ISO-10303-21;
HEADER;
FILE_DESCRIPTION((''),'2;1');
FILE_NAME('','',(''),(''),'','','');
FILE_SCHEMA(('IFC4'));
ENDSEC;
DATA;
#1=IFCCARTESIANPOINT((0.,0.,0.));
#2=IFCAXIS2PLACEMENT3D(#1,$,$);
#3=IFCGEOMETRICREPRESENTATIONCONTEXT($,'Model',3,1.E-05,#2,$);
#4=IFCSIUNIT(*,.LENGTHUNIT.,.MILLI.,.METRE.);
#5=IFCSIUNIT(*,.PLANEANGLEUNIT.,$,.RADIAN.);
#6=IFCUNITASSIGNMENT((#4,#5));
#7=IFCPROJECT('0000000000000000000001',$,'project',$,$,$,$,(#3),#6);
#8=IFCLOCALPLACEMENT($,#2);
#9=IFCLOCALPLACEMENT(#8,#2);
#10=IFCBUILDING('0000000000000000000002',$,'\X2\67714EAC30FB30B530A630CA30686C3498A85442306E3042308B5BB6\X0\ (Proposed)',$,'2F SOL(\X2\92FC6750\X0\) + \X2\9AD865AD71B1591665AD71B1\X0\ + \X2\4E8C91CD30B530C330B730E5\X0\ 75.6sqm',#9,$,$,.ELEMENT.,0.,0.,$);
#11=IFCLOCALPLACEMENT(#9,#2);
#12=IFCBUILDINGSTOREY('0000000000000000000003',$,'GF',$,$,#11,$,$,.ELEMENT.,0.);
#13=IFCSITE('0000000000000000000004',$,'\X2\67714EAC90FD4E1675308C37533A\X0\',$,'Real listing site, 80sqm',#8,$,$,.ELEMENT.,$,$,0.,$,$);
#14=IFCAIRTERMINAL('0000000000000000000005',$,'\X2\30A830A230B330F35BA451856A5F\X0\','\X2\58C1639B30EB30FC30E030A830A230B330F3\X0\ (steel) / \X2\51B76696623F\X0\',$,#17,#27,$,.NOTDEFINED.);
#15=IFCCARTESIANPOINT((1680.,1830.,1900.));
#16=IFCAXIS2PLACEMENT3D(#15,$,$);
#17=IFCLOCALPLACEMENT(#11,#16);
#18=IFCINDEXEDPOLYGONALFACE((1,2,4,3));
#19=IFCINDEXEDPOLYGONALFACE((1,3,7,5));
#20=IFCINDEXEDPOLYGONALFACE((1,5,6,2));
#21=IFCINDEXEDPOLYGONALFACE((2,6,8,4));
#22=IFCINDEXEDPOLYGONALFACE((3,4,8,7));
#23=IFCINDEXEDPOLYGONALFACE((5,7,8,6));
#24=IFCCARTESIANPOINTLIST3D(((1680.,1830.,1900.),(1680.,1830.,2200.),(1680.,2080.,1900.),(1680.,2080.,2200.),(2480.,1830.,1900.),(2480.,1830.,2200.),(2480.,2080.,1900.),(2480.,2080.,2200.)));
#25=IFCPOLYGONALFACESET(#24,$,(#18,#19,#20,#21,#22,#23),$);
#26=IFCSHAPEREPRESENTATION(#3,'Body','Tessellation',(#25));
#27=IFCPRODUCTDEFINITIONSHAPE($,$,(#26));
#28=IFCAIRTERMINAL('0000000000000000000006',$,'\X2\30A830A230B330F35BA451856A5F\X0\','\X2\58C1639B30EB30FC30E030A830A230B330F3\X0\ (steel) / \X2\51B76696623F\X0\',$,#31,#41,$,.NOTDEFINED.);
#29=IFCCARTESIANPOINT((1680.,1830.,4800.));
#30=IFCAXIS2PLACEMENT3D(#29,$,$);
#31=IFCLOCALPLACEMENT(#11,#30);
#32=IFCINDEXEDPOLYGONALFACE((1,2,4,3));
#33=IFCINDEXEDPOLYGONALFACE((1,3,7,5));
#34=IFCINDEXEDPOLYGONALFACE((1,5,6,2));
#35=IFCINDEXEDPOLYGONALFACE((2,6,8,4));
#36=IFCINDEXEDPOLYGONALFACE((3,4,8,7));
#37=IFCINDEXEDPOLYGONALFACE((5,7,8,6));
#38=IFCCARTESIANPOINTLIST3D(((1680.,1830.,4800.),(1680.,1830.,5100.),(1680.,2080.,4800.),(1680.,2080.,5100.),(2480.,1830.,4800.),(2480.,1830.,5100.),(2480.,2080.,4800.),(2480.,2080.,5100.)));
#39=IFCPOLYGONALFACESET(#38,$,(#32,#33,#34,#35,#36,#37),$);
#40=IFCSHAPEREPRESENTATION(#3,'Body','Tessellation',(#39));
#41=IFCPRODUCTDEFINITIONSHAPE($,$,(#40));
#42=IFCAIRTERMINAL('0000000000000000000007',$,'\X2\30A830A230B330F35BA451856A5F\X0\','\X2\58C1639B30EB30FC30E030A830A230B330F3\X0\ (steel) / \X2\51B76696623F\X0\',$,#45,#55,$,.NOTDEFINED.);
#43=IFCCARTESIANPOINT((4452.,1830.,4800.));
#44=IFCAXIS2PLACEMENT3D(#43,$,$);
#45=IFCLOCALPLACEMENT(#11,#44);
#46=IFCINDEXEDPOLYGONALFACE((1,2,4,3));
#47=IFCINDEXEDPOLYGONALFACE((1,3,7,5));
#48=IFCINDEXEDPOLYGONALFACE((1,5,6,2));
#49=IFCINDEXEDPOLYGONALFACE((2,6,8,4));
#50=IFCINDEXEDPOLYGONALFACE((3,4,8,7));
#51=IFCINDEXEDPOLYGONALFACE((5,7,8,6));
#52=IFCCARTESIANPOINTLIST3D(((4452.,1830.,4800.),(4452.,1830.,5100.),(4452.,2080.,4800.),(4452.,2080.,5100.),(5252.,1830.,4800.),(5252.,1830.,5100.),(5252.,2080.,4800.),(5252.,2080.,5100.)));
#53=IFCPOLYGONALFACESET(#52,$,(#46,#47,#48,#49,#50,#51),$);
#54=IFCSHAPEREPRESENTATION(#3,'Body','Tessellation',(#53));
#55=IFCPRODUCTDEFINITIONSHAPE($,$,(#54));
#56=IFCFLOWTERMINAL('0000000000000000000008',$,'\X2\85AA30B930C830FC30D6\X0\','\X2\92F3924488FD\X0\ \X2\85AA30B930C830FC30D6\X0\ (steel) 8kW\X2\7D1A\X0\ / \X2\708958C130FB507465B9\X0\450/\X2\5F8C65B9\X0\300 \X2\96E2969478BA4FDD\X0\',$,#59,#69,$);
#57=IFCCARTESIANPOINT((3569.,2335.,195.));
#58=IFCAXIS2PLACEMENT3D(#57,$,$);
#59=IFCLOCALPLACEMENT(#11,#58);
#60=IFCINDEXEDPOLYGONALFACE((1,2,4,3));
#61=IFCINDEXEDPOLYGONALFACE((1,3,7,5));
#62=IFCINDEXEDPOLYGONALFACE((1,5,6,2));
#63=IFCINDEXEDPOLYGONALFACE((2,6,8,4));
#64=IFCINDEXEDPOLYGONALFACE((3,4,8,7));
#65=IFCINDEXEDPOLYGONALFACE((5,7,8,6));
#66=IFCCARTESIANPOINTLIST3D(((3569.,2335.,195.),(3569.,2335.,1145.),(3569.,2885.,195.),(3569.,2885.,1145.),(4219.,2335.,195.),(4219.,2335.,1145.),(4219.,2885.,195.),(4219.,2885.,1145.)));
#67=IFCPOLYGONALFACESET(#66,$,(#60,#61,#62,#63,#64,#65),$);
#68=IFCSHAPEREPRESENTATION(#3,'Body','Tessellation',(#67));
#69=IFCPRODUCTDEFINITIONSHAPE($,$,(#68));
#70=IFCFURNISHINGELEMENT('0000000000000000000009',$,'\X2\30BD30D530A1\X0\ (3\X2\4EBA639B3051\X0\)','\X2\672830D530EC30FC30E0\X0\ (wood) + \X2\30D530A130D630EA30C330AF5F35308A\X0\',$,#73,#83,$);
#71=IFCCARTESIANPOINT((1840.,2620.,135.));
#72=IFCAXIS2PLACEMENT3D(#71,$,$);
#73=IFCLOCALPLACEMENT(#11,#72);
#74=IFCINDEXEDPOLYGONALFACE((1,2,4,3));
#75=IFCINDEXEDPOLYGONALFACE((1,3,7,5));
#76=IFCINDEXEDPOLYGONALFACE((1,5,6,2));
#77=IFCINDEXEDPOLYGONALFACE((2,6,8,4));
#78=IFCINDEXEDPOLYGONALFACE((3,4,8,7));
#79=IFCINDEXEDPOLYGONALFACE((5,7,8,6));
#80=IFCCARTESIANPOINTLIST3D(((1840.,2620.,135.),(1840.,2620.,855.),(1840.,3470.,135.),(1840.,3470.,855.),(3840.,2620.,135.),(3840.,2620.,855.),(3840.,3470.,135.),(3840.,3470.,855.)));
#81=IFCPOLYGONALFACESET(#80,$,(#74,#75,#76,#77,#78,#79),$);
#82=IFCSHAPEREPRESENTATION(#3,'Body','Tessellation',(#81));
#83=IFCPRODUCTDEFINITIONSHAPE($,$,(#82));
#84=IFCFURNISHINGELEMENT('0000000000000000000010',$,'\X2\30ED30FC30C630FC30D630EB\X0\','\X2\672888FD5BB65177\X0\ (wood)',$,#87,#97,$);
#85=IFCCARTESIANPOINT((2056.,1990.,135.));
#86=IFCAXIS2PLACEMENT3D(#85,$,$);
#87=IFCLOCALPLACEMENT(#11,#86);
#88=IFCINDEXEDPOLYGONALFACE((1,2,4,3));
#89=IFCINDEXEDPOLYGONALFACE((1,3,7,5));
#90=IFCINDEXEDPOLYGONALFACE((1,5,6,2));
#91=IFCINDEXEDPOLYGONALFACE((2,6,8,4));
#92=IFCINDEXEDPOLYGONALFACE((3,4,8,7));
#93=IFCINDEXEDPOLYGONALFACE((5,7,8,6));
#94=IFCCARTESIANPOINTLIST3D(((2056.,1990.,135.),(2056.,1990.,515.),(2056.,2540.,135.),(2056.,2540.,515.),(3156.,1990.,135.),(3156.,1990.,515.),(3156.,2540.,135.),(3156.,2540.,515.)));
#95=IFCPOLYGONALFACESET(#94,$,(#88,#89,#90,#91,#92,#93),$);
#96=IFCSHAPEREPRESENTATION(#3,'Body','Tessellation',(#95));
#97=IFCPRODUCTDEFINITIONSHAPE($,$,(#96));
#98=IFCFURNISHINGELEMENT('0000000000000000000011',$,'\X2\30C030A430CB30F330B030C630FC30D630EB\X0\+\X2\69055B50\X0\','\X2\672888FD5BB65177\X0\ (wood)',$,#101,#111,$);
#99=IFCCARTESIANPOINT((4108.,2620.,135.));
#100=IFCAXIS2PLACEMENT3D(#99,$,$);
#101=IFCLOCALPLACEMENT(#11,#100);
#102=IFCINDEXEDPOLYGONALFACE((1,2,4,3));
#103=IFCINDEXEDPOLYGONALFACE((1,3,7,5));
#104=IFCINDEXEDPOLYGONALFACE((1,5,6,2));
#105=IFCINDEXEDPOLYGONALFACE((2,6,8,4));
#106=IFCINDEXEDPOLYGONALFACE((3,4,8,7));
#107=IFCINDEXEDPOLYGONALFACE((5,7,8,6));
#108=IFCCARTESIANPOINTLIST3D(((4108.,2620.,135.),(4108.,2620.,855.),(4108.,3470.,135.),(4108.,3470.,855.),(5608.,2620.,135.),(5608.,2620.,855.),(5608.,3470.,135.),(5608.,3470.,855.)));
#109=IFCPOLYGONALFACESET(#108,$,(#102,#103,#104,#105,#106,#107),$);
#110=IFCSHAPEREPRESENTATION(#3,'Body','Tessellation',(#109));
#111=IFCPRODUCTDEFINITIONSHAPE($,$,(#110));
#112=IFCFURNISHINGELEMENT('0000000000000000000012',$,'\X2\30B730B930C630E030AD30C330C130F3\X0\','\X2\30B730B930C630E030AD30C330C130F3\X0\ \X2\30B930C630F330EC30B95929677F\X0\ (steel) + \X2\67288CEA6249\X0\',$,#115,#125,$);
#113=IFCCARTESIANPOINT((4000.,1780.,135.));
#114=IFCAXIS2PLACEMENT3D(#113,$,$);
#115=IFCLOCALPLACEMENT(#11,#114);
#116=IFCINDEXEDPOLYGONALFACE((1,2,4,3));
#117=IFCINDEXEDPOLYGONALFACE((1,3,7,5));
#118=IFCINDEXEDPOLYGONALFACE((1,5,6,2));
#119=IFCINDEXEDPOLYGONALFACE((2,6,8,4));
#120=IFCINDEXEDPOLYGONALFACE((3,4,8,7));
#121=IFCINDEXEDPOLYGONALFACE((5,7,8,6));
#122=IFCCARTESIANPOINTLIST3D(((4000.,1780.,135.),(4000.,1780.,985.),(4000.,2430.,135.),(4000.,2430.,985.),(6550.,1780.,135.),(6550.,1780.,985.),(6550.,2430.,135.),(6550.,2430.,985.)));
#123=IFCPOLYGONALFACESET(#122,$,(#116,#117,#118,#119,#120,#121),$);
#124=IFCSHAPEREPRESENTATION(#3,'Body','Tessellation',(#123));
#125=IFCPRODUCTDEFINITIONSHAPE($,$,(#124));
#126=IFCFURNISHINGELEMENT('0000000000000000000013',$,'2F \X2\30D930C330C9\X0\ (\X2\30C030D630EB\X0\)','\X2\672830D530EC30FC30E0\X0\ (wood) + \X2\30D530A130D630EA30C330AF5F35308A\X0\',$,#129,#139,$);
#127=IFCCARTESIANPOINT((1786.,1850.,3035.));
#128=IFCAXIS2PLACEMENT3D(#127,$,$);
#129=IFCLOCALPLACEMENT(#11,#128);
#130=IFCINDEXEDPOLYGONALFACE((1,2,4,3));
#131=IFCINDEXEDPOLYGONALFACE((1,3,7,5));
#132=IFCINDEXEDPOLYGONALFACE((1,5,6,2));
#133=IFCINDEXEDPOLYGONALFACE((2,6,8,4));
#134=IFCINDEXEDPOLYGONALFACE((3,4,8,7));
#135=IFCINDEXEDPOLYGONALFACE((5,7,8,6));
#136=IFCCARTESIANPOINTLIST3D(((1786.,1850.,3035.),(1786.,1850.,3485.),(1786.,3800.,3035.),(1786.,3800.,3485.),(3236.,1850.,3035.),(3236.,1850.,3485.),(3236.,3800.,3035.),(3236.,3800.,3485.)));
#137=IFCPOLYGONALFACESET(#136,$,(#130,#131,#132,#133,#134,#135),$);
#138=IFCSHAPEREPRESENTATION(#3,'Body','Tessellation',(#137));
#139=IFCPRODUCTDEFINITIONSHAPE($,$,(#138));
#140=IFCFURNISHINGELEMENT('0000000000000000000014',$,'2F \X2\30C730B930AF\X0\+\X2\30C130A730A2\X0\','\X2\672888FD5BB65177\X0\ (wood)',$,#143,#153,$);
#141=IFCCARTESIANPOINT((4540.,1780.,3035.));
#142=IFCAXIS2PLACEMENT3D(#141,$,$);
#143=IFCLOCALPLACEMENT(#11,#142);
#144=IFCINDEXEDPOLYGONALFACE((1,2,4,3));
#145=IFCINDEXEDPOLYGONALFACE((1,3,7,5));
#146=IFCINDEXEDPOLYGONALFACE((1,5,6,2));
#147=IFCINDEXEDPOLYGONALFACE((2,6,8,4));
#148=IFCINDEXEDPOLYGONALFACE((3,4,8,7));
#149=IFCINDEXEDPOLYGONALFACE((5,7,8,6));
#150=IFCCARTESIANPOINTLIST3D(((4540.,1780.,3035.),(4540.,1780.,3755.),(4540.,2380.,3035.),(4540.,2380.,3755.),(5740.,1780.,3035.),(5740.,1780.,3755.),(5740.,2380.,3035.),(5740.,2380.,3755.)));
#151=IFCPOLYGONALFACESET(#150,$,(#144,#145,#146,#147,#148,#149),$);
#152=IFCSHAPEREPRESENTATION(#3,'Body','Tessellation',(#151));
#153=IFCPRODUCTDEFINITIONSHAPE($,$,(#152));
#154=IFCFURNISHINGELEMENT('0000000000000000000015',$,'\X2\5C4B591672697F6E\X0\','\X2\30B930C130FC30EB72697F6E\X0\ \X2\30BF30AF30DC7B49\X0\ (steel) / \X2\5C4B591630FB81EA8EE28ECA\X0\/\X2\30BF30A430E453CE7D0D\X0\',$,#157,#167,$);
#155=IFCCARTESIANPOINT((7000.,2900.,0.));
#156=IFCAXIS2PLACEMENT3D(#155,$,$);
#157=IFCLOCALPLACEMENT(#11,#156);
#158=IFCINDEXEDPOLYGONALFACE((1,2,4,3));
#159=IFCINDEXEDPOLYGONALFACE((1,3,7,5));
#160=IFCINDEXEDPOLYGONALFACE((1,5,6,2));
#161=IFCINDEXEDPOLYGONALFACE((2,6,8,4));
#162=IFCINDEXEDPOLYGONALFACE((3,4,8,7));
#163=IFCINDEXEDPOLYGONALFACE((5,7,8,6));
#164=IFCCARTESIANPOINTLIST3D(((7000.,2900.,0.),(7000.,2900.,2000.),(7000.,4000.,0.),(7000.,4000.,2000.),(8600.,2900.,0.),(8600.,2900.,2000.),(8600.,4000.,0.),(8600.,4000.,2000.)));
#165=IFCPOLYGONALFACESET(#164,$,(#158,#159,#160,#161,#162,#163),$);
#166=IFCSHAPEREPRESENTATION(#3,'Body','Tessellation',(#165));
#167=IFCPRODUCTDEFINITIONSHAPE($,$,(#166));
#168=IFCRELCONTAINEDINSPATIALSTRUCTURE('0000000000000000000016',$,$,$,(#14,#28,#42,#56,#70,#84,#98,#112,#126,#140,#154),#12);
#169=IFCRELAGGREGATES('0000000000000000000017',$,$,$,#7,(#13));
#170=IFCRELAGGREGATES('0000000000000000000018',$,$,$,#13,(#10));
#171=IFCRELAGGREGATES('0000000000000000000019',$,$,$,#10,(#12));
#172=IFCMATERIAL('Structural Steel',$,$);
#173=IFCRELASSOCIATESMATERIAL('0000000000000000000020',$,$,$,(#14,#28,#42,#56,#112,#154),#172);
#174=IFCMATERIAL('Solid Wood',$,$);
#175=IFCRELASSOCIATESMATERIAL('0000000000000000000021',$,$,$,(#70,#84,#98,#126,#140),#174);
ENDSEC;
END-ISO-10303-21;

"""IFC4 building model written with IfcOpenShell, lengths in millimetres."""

from ifc_helpers import new_model, si_unit, frame, frame_2d, origin, place, context, project, spatial, rectangle, extrude, material, element, save


model = new_model("IFC4")

# Units and contexts
model_context = context("Model", 3, precision=1e-05, world=origin())
ifc_project = project(units=[si_unit("LENGTHUNIT", "METRE", prefix="MILLI"), si_unit("PLANEANGLEUNIT", "RADIAN")], contexts=[model_context])

# Site, building, storey
site_placement = place(None, origin())
site = spatial("IfcSite", under=ifc_project, at=site_placement, Name="東京都世田谷区", ObjectType="Real listing site, 80sqm", CompositionType="ELEMENT", RefElevation=0.0)
building_placement = place(site_placement, origin())
building = spatial("IfcBuilding", under=site, at=building_placement, Name="東京・サウナと水風呂のある家 (Proposed)", ObjectType="2F SOL(鋼材) + 高断熱外断熱 + 二重サッシュ 75.6sqm", CompositionType="ELEMENT", ElevationOfRefHeight=0.0, ElevationOfTerrain=0.0)
storey_placement = place(building_placement, origin())
storey = spatial("IfcBuildingStorey", under=building, at=storey_placement, Name="GF", CompositionType="ELEMENT", Elevation=0.0)

# Shared definitions
ifc_material_1 = material(Name="Solid Wood")

# Shared definitions
ifc_material_2 = material(Name="Structural Steel")

# Air terminals
air_terminal_1_placement = place(storey_placement, frame((1680.0, 1830.0, 1900.0)))
element("IfcAirTerminal", 1, at=air_terminal_1_placement, inside=storey, material=ifc_material_2, Name="エアコン室内機", Description="壁掛ルームエアコン (steel) / 冷暖房", PredefinedType="NOTDEFINED", context=model_context, shape_type="SweptSolid", body=[
    extrude(rectangle(XDim=800.0, YDim=250.0, at=frame_2d((400.0, 125.0))), frame((1680.0, 1830.0, 1900.0)), (0.0, 0.0, 1.0), 300.0),
])
air_terminal_2_placement = place(storey_placement, frame((1680.0, 1830.0, 4800.0)))
element("IfcAirTerminal", 2, at=air_terminal_2_placement, inside=storey, material=ifc_material_2, Name="エアコン室内機", Description="壁掛ルームエアコン (steel) / 冷暖房", PredefinedType="NOTDEFINED", context=model_context, shape_type="SweptSolid", body=[
    extrude(rectangle(XDim=800.0, YDim=250.0, at=frame_2d((400.0, 125.0))), frame((1680.0, 1830.0, 4800.0)), (0.0, 0.0, 1.0), 300.0),
])
air_terminal_3_placement = place(storey_placement, frame((4452.0, 1830.0, 4800.0)))
element("IfcAirTerminal", 3, at=air_terminal_3_placement, inside=storey, material=ifc_material_2, Name="エアコン室内機", Description="壁掛ルームエアコン (steel) / 冷暖房", PredefinedType="NOTDEFINED", context=model_context, shape_type="SweptSolid", body=[
    extrude(rectangle(XDim=800.0, YDim=250.0, at=frame_2d((400.0, 125.0))), frame((4452.0, 1830.0, 4800.0)), (0.0, 0.0, 1.0), 300.0),
])

# Flow terminal
flow_terminal_1_placement = place(storey_placement, frame((3569.0, 2335.0, 195.0)))
element("IfcFlowTerminal", 4, at=flow_terminal_1_placement, inside=storey, material=ifc_material_2, Name="薪ストーブ", Description="鋳鉄製 薪ストーブ (steel) 8kW級 / 炉壁・側方450/後方300 離隔確保", context=model_context, shape_type="SweptSolid", body=[
    extrude(rectangle(XDim=650.0, YDim=550.0, at=frame_2d((325.0, 275.0))), frame((3569.0, 2335.0, 195.0)), (0.0, 0.0, 1.0), 950.0),
])

# Furnishing elements
furnishing_1_placement = place(storey_placement, frame((1840.0, 2620.0, 135.0)))
element("IfcFurnishingElement", 5, at=furnishing_1_placement, inside=storey, material=ifc_material_1, Name="ソファ (3人掛け)", Description="木フレーム (wood) + ファブリック張り", context=model_context, shape_type="SweptSolid", body=[
    extrude(rectangle(XDim=2000.0, YDim=850.0, at=frame_2d((1000.0, 425.0))), frame((1840.0, 2620.0, 135.0)), (0.0, 0.0, 1.0), 720.0),
])
furnishing_2_placement = place(storey_placement, frame((2056.0, 1990.0, 135.0)))
element("IfcFurnishingElement", 6, at=furnishing_2_placement, inside=storey, material=ifc_material_1, Name="ローテーブル", Description="木製家具 (wood)", context=model_context, shape_type="SweptSolid", body=[
    extrude(rectangle(XDim=1100.0, YDim=550.0, at=frame_2d((550.0, 275.0))), frame((2056.0, 1990.0, 135.0)), (0.0, 0.0, 1.0), 380.0),
])
furnishing_3_placement = place(storey_placement, frame((4108.0, 2620.0, 135.0)))
element("IfcFurnishingElement", 7, at=furnishing_3_placement, inside=storey, material=ifc_material_1, Name="ダイニングテーブル+椅子", Description="木製家具 (wood)", context=model_context, shape_type="SweptSolid", body=[
    extrude(rectangle(XDim=1500.0, YDim=850.0, at=frame_2d((750.0, 425.0))), frame((4108.0, 2620.0, 135.0)), (0.0, 0.0, 1.0), 720.0),
])
furnishing_4_placement = place(storey_placement, frame((4000.0, 1780.0, 135.0)))
element("IfcFurnishingElement", 8, at=furnishing_4_placement, inside=storey, material=ifc_material_2, Name="システムキッチン", Description="システムキッチン ステンレス天板 (steel) + 木質扉", context=model_context, shape_type="SweptSolid", body=[
    extrude(rectangle(XDim=2550.0, YDim=650.0, at=frame_2d((1275.0, 325.0))), frame((4000.0, 1780.0, 135.0)), (0.0, 0.0, 1.0), 850.0),
])
furnishing_5_placement = place(storey_placement, frame((1786.0, 1850.0, 3035.0)))
element("IfcFurnishingElement", 9, at=furnishing_5_placement, inside=storey, material=ifc_material_1, Name="2F ベッド (ダブル)", Description="木フレーム (wood) + ファブリック張り", context=model_context, shape_type="SweptSolid", body=[
    extrude(rectangle(XDim=1450.0, YDim=1950.0, at=frame_2d((725.0, 975.0))), frame((1786.0, 1850.0, 3035.0)), (0.0, 0.0, 1.0), 450.0),
])
furnishing_6_placement = place(storey_placement, frame((4540.0, 1780.0, 3035.0)))
element("IfcFurnishingElement", 10, at=furnishing_6_placement, inside=storey, material=ifc_material_1, Name="2F デスク+チェア", Description="木製家具 (wood)", context=model_context, shape_type="SweptSolid", body=[
    extrude(rectangle(XDim=1200.0, YDim=600.0, at=frame_2d((600.0, 300.0))), frame((4540.0, 1780.0, 3035.0)), (0.0, 0.0, 1.0), 720.0),
])
furnishing_7_placement = place(storey_placement, frame((7000.0, 2900.0, 0.0)))
element("IfcFurnishingElement", 11, at=furnishing_7_placement, inside=storey, material=ifc_material_2, Name="屋外物置", Description="スチール物置 タクボ等 (steel) / 屋外・自転車/タイヤ収納", context=model_context, shape_type="SweptSolid", body=[
    extrude(rectangle(XDim=1600.0, YDim=1100.0, at=frame_2d((800.0, 550.0))), frame((7000.0, 2900.0, 0.0)), (0.0, 0.0, 1.0), 2000.0),
])

save(model, "model.ifc")
